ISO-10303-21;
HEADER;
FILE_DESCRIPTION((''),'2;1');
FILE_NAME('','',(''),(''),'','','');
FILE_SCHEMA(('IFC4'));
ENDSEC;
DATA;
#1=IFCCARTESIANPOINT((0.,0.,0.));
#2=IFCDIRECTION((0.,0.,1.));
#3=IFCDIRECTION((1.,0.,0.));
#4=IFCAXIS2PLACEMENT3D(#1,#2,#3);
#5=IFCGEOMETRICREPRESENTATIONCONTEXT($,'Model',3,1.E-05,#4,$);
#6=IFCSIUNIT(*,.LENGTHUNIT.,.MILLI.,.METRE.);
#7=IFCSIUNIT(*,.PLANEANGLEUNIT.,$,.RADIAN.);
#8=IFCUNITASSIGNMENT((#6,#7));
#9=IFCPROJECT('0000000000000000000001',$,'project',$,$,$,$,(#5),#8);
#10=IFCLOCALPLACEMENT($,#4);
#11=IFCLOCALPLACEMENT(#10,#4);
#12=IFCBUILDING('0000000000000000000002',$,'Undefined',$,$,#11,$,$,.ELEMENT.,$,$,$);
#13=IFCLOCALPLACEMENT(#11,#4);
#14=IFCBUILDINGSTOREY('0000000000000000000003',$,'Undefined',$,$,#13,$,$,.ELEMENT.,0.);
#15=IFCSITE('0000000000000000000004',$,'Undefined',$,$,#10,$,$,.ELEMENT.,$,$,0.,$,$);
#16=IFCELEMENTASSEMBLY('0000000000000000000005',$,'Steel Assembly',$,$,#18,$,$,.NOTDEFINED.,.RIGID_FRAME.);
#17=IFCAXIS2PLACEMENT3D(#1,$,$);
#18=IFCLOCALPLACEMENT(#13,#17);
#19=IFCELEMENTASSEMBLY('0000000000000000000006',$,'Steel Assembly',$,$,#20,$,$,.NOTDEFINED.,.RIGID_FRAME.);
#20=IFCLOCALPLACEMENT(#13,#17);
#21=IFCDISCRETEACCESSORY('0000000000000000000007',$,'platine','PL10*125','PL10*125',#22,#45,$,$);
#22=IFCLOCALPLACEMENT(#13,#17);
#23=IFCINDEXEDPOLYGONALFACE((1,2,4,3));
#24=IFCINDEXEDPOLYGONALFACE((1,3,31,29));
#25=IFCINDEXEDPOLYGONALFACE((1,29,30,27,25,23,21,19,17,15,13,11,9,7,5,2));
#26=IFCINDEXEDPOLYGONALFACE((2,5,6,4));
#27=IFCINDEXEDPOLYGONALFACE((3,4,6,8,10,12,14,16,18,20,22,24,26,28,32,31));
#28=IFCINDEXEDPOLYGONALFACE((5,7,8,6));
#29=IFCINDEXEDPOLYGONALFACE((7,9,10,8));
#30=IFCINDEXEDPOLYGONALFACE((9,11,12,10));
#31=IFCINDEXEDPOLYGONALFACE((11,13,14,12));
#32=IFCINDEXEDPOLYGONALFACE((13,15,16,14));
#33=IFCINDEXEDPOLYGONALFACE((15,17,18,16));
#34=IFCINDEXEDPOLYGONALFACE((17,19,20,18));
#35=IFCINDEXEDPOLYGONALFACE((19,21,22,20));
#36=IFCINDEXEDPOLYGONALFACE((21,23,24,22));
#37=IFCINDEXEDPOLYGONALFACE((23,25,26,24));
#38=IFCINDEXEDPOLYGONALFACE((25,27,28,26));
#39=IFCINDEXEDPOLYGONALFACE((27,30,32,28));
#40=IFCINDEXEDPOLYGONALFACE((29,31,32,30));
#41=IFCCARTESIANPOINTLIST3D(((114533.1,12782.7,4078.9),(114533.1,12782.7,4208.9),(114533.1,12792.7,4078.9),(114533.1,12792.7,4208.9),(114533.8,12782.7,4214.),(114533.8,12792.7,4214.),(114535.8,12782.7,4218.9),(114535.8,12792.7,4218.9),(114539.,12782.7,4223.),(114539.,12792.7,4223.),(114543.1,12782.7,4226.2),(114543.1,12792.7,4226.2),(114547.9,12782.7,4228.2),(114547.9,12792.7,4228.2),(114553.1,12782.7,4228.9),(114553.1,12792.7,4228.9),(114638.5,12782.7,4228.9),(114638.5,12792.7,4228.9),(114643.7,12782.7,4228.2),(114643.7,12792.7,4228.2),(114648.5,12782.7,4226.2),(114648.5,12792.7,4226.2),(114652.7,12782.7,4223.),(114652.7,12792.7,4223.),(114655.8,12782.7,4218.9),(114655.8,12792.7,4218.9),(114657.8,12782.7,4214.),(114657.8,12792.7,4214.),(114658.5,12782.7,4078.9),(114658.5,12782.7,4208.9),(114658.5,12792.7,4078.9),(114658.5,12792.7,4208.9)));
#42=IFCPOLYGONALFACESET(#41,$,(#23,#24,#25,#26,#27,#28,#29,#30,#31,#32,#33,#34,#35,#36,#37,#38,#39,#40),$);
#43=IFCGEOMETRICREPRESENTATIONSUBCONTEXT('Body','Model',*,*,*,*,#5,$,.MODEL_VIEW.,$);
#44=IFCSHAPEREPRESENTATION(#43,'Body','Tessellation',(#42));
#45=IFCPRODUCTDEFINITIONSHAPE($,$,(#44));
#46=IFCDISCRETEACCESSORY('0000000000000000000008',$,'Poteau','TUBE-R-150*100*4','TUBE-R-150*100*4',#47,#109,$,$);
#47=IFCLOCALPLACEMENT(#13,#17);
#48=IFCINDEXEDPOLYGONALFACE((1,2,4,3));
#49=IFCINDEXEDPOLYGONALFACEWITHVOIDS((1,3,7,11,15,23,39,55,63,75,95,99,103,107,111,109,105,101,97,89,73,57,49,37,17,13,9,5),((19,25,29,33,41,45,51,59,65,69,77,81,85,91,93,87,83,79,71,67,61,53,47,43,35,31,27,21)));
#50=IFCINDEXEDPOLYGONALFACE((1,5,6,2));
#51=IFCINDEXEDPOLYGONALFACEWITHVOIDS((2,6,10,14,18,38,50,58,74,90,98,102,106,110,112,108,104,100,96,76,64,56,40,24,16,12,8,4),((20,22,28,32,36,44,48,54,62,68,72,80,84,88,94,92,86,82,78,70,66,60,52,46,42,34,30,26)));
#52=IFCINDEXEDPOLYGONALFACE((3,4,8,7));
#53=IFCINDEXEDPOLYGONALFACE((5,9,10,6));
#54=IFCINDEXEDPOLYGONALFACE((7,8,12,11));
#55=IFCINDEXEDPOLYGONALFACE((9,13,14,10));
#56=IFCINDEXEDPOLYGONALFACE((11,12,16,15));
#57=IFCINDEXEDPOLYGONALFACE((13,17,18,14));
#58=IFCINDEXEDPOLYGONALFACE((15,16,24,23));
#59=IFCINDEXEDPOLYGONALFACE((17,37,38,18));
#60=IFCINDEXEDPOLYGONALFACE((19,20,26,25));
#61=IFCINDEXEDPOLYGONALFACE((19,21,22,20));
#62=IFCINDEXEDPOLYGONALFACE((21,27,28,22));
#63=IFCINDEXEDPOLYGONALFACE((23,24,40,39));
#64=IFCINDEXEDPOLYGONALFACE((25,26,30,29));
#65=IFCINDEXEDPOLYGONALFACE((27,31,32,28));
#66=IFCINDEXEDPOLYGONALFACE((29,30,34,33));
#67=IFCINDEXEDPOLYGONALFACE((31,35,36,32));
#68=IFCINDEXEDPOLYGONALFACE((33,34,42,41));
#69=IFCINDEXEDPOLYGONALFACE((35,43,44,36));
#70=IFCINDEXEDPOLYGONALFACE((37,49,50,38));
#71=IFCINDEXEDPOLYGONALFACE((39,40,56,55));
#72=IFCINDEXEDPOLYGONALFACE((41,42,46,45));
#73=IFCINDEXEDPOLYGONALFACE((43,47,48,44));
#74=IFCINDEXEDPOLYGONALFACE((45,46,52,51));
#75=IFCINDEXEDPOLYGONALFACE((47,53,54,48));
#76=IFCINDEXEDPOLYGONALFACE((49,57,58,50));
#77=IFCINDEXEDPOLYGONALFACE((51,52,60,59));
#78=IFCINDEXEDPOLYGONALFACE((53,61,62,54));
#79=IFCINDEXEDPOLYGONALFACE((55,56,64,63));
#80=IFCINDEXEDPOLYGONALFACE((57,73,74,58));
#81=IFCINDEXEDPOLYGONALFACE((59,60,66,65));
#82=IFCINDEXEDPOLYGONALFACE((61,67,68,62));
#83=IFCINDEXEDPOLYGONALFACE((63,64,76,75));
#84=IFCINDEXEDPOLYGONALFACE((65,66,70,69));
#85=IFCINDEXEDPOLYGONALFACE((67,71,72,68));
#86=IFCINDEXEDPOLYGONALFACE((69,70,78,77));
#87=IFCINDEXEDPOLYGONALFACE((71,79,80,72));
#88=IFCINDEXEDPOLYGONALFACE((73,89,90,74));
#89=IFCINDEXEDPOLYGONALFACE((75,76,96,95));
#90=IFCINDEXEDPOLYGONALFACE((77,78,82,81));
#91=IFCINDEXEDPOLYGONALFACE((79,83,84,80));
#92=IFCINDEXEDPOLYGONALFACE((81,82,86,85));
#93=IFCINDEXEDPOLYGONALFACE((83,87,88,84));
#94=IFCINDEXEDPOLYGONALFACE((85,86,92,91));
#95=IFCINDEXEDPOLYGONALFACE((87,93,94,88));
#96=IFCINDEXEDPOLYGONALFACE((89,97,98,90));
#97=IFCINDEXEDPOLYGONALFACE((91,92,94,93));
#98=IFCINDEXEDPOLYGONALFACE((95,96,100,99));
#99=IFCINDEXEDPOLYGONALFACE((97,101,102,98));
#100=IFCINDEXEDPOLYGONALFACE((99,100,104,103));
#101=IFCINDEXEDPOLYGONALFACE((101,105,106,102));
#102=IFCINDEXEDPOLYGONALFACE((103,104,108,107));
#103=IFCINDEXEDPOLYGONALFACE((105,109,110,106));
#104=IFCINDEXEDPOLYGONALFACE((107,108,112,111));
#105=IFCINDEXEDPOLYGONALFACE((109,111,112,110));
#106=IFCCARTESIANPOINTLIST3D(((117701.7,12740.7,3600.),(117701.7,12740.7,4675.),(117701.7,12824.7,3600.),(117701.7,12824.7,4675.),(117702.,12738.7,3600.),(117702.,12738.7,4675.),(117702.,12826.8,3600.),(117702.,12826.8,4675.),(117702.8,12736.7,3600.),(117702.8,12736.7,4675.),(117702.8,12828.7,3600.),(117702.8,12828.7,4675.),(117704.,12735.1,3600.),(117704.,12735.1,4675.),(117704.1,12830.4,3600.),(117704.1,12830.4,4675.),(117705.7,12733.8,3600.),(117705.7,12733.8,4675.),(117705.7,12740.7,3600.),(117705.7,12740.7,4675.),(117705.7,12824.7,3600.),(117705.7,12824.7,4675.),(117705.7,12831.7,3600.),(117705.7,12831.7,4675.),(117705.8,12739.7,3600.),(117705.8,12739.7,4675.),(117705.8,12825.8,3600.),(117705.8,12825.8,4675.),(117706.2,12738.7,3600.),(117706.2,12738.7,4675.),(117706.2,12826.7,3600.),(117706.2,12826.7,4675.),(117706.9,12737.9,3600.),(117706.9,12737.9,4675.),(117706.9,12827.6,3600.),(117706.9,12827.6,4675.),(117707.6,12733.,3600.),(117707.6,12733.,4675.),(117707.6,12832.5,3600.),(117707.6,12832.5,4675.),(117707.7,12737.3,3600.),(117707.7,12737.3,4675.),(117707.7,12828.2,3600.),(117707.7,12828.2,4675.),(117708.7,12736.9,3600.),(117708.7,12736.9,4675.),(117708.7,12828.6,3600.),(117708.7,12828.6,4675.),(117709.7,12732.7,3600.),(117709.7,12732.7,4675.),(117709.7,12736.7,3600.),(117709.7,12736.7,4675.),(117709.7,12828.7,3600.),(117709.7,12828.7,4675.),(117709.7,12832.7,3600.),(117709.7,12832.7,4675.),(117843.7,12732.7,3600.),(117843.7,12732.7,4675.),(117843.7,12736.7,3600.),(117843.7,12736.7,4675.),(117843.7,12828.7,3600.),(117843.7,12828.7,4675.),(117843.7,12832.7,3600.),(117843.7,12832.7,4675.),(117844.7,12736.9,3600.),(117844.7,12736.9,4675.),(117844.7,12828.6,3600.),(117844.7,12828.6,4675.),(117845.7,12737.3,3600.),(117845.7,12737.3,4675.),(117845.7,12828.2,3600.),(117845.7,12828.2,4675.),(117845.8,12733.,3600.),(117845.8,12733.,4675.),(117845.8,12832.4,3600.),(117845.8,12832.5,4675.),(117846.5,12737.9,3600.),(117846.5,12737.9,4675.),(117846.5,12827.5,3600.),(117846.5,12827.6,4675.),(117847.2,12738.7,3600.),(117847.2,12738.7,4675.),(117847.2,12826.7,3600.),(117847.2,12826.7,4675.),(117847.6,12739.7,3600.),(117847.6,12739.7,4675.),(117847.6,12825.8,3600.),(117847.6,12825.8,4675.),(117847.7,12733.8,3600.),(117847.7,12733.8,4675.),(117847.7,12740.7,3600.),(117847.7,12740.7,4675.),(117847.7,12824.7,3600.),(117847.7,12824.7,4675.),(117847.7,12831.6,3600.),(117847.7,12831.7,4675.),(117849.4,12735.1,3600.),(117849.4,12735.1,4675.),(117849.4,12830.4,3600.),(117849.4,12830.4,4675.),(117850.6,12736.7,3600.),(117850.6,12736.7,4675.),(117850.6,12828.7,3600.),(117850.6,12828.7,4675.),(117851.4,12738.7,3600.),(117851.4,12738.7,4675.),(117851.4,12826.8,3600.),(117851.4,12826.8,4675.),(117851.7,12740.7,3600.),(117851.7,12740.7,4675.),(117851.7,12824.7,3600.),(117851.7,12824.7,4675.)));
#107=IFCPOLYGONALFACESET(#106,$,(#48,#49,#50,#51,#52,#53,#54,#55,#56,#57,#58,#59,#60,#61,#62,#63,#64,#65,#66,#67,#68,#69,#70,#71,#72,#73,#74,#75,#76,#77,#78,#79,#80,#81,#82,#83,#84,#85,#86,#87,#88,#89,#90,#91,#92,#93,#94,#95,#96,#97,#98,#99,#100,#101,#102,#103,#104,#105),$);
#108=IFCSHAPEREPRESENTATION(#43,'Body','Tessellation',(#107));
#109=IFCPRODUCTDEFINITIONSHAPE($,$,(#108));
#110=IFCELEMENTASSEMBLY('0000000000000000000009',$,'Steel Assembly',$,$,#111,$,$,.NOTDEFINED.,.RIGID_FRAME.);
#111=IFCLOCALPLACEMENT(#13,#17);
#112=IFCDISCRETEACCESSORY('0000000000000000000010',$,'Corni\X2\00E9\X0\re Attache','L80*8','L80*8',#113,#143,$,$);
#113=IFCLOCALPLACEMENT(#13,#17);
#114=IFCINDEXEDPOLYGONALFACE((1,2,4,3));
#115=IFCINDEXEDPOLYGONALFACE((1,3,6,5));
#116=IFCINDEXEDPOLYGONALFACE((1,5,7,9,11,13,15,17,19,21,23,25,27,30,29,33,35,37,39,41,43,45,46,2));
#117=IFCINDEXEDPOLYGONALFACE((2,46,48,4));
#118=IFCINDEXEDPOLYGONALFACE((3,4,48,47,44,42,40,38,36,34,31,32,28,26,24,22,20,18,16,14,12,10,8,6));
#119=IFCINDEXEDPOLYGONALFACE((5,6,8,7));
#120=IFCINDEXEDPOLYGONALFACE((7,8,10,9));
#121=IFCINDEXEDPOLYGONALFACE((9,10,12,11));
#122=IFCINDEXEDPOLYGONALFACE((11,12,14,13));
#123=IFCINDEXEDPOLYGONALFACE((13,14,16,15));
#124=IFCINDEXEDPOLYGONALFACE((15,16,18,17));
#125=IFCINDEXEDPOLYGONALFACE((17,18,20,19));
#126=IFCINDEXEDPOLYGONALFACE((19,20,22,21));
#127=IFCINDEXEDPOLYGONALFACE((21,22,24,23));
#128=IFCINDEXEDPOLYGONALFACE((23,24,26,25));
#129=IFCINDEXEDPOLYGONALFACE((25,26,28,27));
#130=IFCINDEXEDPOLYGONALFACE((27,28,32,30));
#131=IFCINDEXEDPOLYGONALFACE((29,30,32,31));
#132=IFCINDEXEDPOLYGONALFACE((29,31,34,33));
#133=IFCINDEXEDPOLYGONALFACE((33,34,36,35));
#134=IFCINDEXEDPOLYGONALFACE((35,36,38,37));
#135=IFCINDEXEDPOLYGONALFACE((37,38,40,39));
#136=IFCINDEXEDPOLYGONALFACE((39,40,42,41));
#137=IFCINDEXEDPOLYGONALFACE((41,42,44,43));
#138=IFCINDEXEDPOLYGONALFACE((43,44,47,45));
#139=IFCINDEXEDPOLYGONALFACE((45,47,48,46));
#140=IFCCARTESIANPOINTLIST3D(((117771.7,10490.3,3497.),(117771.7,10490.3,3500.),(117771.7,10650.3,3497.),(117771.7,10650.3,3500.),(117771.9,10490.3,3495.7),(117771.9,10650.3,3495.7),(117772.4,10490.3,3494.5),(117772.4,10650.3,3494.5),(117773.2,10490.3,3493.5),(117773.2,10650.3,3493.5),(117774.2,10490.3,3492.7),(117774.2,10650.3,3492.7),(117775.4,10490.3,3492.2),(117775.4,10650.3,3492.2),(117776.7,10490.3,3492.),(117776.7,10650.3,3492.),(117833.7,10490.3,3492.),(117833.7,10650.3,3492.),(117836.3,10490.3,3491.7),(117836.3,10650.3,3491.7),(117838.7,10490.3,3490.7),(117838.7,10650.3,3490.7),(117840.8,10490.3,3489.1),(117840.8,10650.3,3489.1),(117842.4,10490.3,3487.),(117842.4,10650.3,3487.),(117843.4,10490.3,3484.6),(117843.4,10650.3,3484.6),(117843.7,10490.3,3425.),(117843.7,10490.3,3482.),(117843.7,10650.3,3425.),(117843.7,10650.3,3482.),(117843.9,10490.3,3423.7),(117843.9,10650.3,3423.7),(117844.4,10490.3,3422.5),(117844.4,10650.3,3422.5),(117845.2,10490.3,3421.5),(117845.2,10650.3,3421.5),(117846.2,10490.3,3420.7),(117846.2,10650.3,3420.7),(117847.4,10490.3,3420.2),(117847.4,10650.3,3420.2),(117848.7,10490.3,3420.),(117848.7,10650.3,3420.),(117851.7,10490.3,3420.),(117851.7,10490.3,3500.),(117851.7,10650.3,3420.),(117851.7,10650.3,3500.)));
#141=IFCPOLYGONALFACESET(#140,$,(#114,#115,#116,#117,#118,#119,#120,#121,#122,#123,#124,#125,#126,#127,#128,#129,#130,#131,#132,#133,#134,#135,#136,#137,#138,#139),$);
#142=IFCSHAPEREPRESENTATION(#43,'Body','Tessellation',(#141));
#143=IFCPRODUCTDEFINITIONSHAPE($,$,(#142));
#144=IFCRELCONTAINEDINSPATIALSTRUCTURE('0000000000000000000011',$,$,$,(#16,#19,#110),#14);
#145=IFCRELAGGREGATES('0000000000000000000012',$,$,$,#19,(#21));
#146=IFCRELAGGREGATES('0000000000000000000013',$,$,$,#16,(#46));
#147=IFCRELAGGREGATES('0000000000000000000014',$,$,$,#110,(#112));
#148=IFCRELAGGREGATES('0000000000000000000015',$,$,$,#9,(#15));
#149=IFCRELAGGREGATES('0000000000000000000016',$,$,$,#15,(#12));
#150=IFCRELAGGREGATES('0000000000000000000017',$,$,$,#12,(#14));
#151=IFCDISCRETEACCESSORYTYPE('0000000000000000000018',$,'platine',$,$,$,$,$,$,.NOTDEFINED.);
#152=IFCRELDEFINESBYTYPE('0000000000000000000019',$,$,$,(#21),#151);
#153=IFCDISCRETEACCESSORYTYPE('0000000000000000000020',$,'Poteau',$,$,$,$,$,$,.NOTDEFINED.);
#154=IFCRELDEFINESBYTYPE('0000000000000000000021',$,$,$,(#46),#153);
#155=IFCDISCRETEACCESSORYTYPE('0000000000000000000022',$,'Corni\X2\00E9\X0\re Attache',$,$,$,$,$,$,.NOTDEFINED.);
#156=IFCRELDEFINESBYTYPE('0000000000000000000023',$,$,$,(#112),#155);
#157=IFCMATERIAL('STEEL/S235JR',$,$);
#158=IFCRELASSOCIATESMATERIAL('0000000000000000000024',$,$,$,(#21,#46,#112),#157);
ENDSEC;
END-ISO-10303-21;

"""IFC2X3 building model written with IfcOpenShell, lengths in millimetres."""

from ifc_helpers import new_model, si_unit, frame, frame_2d, origin_with_axes, origin_2d_with_axis, place, context, subcontext, project, spatial, polyline, circle_curve, parameter, trimmed, segment, composite_curve, rectangle, hollow_rectangle, l_section, outline, extrude, boolean, material, type_object, element, aggregate, save


model = new_model("IFC2X3")

# Units and contexts
model_context = context("Model", 3, precision=1e-05, world=origin_with_axes())
body_context = subcontext(model_context, "Body", "Model", "MODEL_VIEW")
ifc_project = project(units=[si_unit("LENGTHUNIT", "METRE", prefix="MILLI"), si_unit("PLANEANGLEUNIT", "RADIAN")], contexts=[model_context])

# Site, building, storey
site_placement = place(None, origin_with_axes())
site = spatial("IfcSite", under=ifc_project, at=site_placement, Name="Undefined", CompositionType="ELEMENT", RefElevation=0.0)
building_placement = place(site_placement, origin_with_axes())
building = spatial("IfcBuilding", under=site, at=building_placement, Name="Undefined", CompositionType="ELEMENT")
storey_placement = place(building_placement, origin_with_axes())
storey = spatial("IfcBuildingStorey", under=building, at=storey_placement, Name="Undefined", CompositionType="ELEMENT", Elevation=0.0)

# Shared definitions
ifc_material_1 = material(Name="STEEL/S235JR")

# Element assembly
assembly_1_placement = place(storey_placement, origin_with_axes())
assembly_1 = element("IfcElementAssembly", 1, at=assembly_1_placement, inside=storey, Name="Steel Assembly", AssemblyPlace="NOTDEFINED", PredefinedType="RIGID_FRAME")

# Element assembly, discrete accessory
assembly_2_placement = place(storey_placement, origin_with_axes())
assembly_2 = element("IfcElementAssembly", 2, at=assembly_2_placement, inside=storey, Name="Steel Assembly", AssemblyPlace="NOTDEFINED", PredefinedType="RIGID_FRAME")
discrete_accessory_type_1 = type_object("IfcDiscreteAccessoryType", Name="platine")
discrete_accessory_1_placement = place(assembly_2_placement, frame((114533.1, 12787.7, 4078.9), z_axis=(0.0, -1.0, 0.0), x_axis=(1.0, 0.0, -0.000002)))
discrete_accessory_1 = element("IfcDiscreteAccessory", 3, at=discrete_accessory_1_placement, type_object=discrete_accessory_type_1, material=ifc_material_1, Name="platine", Description="PL10*125", ObjectType="PL10*125", context=body_context, shape_type="CSG", body=[
    boolean("DIFFERENCE", extrude(outline(composite_curve([segment(polyline([(0.0, 130.0), (0.0, 0.0), (125.4, 0.0), (125.4, 130.0)]), True, "CONTINUOUS"), segment(trimmed(circle_curve(frame_2d((105.4, 130.0), x_axis=(1.0, 0.000002)), 20.0), [parameter(0.0)], [parameter(1.5708)], True, "PARAMETER"), True, "CONTINUOUS"), segment(polyline([(105.4, 150.0), (20.0, 150.0)]), True, "CONTINUOUS"), segment(trimmed(circle_curve(frame_2d((20.0, 130.0), x_axis=(0.0, 1.0)), 20.0), [parameter(0.0)], [parameter(1.5708)], True, "PARAMETER"), True, "DISCONTINUOUS")], self_intersect=False)), frame((0.0, 0.0, -5.0), z_axis=(0.0, 0.0, 1.0), x_axis=(1.0, 0.0, 0.0)), (0.0, 0.0, 1.0), 10.0), extrude(rectangle(XDim=0.0, YDim=0.0, at=origin_2d_with_axis()), frame((62.6, 0.0, -220.0), z_axis=(0.0, 0.0, 1.0), x_axis=(1.0, 0.000002, 0.0)), (0.0, 0.0, 1.0), 5347.7)),
])
aggregate(assembly_2, [discrete_accessory_1])

# Discrete accessory
discrete_accessory_type_2 = type_object("IfcDiscreteAccessoryType", Name="Poteau")
discrete_accessory_2_placement = place(assembly_1_placement, frame((117776.7, 12782.7, 3600.0), z_axis=(0.0, 0.0, 1.0), x_axis=(1.0, 0.0, 0.0)))
discrete_accessory_2 = element("IfcDiscreteAccessory", 4, at=discrete_accessory_2_placement, type_object=discrete_accessory_type_2, material=ifc_material_1, Name="Poteau", Description="TUBE-R-150*100*4", ObjectType="TUBE-R-150*100*4", context=body_context, shape_type="SweptSolid", body=[
    extrude(hollow_rectangle(XDim=100.0, YDim=150.0, WallThickness=4.0, InnerFilletRadius=4.0, OuterFilletRadius=8.0, at=origin_2d_with_axis()), frame((0.0, 0.0, 1075.0), z_axis=(0.0, -0.000003, -1.0), x_axis=(-0.000045, -1.0, 0.000003)), (0.0, 0.0, 1.0), 1075.0),
])
aggregate(assembly_1, [discrete_accessory_2])

# Element assembly, discrete accessory
assembly_3_placement = place(storey_placement, origin_with_axes())
assembly_3 = element("IfcElementAssembly", 5, at=assembly_3_placement, inside=storey, Name="Steel Assembly", AssemblyPlace="NOTDEFINED", PredefinedType="RIGID_FRAME")
discrete_accessory_type_3 = type_object("IfcDiscreteAccessoryType", Name="Corniére Attache")
discrete_accessory_3_placement = place(assembly_3_placement, frame((117811.7, 10650.3, 3460.0), z_axis=(-1.0, 0.0, 0.0), x_axis=(0.0, -1.0, 0.000002)))
discrete_accessory_3 = element("IfcDiscreteAccessory", 6, at=discrete_accessory_3_placement, type_object=discrete_accessory_type_3, material=ifc_material_1, Name="Corniére Attache", Description="L80*8", ObjectType="L80*8", context=body_context, shape_type="SweptSolid", body=[
    extrude(l_section(Depth=80.0, Width=80.0, Thickness=8.0, FilletRadius=10.0, EdgeRadius=5.0, at=origin_2d_with_axis()), frame((160.0, 0.0, 0.0), z_axis=(-1.0, 0.0, 0.0), x_axis=(0.0, -1.0, 0.0)), (0.0, 0.0, 1.0), 160.0),
])
aggregate(assembly_3, [discrete_accessory_3])

save(model, "model.ifc")
